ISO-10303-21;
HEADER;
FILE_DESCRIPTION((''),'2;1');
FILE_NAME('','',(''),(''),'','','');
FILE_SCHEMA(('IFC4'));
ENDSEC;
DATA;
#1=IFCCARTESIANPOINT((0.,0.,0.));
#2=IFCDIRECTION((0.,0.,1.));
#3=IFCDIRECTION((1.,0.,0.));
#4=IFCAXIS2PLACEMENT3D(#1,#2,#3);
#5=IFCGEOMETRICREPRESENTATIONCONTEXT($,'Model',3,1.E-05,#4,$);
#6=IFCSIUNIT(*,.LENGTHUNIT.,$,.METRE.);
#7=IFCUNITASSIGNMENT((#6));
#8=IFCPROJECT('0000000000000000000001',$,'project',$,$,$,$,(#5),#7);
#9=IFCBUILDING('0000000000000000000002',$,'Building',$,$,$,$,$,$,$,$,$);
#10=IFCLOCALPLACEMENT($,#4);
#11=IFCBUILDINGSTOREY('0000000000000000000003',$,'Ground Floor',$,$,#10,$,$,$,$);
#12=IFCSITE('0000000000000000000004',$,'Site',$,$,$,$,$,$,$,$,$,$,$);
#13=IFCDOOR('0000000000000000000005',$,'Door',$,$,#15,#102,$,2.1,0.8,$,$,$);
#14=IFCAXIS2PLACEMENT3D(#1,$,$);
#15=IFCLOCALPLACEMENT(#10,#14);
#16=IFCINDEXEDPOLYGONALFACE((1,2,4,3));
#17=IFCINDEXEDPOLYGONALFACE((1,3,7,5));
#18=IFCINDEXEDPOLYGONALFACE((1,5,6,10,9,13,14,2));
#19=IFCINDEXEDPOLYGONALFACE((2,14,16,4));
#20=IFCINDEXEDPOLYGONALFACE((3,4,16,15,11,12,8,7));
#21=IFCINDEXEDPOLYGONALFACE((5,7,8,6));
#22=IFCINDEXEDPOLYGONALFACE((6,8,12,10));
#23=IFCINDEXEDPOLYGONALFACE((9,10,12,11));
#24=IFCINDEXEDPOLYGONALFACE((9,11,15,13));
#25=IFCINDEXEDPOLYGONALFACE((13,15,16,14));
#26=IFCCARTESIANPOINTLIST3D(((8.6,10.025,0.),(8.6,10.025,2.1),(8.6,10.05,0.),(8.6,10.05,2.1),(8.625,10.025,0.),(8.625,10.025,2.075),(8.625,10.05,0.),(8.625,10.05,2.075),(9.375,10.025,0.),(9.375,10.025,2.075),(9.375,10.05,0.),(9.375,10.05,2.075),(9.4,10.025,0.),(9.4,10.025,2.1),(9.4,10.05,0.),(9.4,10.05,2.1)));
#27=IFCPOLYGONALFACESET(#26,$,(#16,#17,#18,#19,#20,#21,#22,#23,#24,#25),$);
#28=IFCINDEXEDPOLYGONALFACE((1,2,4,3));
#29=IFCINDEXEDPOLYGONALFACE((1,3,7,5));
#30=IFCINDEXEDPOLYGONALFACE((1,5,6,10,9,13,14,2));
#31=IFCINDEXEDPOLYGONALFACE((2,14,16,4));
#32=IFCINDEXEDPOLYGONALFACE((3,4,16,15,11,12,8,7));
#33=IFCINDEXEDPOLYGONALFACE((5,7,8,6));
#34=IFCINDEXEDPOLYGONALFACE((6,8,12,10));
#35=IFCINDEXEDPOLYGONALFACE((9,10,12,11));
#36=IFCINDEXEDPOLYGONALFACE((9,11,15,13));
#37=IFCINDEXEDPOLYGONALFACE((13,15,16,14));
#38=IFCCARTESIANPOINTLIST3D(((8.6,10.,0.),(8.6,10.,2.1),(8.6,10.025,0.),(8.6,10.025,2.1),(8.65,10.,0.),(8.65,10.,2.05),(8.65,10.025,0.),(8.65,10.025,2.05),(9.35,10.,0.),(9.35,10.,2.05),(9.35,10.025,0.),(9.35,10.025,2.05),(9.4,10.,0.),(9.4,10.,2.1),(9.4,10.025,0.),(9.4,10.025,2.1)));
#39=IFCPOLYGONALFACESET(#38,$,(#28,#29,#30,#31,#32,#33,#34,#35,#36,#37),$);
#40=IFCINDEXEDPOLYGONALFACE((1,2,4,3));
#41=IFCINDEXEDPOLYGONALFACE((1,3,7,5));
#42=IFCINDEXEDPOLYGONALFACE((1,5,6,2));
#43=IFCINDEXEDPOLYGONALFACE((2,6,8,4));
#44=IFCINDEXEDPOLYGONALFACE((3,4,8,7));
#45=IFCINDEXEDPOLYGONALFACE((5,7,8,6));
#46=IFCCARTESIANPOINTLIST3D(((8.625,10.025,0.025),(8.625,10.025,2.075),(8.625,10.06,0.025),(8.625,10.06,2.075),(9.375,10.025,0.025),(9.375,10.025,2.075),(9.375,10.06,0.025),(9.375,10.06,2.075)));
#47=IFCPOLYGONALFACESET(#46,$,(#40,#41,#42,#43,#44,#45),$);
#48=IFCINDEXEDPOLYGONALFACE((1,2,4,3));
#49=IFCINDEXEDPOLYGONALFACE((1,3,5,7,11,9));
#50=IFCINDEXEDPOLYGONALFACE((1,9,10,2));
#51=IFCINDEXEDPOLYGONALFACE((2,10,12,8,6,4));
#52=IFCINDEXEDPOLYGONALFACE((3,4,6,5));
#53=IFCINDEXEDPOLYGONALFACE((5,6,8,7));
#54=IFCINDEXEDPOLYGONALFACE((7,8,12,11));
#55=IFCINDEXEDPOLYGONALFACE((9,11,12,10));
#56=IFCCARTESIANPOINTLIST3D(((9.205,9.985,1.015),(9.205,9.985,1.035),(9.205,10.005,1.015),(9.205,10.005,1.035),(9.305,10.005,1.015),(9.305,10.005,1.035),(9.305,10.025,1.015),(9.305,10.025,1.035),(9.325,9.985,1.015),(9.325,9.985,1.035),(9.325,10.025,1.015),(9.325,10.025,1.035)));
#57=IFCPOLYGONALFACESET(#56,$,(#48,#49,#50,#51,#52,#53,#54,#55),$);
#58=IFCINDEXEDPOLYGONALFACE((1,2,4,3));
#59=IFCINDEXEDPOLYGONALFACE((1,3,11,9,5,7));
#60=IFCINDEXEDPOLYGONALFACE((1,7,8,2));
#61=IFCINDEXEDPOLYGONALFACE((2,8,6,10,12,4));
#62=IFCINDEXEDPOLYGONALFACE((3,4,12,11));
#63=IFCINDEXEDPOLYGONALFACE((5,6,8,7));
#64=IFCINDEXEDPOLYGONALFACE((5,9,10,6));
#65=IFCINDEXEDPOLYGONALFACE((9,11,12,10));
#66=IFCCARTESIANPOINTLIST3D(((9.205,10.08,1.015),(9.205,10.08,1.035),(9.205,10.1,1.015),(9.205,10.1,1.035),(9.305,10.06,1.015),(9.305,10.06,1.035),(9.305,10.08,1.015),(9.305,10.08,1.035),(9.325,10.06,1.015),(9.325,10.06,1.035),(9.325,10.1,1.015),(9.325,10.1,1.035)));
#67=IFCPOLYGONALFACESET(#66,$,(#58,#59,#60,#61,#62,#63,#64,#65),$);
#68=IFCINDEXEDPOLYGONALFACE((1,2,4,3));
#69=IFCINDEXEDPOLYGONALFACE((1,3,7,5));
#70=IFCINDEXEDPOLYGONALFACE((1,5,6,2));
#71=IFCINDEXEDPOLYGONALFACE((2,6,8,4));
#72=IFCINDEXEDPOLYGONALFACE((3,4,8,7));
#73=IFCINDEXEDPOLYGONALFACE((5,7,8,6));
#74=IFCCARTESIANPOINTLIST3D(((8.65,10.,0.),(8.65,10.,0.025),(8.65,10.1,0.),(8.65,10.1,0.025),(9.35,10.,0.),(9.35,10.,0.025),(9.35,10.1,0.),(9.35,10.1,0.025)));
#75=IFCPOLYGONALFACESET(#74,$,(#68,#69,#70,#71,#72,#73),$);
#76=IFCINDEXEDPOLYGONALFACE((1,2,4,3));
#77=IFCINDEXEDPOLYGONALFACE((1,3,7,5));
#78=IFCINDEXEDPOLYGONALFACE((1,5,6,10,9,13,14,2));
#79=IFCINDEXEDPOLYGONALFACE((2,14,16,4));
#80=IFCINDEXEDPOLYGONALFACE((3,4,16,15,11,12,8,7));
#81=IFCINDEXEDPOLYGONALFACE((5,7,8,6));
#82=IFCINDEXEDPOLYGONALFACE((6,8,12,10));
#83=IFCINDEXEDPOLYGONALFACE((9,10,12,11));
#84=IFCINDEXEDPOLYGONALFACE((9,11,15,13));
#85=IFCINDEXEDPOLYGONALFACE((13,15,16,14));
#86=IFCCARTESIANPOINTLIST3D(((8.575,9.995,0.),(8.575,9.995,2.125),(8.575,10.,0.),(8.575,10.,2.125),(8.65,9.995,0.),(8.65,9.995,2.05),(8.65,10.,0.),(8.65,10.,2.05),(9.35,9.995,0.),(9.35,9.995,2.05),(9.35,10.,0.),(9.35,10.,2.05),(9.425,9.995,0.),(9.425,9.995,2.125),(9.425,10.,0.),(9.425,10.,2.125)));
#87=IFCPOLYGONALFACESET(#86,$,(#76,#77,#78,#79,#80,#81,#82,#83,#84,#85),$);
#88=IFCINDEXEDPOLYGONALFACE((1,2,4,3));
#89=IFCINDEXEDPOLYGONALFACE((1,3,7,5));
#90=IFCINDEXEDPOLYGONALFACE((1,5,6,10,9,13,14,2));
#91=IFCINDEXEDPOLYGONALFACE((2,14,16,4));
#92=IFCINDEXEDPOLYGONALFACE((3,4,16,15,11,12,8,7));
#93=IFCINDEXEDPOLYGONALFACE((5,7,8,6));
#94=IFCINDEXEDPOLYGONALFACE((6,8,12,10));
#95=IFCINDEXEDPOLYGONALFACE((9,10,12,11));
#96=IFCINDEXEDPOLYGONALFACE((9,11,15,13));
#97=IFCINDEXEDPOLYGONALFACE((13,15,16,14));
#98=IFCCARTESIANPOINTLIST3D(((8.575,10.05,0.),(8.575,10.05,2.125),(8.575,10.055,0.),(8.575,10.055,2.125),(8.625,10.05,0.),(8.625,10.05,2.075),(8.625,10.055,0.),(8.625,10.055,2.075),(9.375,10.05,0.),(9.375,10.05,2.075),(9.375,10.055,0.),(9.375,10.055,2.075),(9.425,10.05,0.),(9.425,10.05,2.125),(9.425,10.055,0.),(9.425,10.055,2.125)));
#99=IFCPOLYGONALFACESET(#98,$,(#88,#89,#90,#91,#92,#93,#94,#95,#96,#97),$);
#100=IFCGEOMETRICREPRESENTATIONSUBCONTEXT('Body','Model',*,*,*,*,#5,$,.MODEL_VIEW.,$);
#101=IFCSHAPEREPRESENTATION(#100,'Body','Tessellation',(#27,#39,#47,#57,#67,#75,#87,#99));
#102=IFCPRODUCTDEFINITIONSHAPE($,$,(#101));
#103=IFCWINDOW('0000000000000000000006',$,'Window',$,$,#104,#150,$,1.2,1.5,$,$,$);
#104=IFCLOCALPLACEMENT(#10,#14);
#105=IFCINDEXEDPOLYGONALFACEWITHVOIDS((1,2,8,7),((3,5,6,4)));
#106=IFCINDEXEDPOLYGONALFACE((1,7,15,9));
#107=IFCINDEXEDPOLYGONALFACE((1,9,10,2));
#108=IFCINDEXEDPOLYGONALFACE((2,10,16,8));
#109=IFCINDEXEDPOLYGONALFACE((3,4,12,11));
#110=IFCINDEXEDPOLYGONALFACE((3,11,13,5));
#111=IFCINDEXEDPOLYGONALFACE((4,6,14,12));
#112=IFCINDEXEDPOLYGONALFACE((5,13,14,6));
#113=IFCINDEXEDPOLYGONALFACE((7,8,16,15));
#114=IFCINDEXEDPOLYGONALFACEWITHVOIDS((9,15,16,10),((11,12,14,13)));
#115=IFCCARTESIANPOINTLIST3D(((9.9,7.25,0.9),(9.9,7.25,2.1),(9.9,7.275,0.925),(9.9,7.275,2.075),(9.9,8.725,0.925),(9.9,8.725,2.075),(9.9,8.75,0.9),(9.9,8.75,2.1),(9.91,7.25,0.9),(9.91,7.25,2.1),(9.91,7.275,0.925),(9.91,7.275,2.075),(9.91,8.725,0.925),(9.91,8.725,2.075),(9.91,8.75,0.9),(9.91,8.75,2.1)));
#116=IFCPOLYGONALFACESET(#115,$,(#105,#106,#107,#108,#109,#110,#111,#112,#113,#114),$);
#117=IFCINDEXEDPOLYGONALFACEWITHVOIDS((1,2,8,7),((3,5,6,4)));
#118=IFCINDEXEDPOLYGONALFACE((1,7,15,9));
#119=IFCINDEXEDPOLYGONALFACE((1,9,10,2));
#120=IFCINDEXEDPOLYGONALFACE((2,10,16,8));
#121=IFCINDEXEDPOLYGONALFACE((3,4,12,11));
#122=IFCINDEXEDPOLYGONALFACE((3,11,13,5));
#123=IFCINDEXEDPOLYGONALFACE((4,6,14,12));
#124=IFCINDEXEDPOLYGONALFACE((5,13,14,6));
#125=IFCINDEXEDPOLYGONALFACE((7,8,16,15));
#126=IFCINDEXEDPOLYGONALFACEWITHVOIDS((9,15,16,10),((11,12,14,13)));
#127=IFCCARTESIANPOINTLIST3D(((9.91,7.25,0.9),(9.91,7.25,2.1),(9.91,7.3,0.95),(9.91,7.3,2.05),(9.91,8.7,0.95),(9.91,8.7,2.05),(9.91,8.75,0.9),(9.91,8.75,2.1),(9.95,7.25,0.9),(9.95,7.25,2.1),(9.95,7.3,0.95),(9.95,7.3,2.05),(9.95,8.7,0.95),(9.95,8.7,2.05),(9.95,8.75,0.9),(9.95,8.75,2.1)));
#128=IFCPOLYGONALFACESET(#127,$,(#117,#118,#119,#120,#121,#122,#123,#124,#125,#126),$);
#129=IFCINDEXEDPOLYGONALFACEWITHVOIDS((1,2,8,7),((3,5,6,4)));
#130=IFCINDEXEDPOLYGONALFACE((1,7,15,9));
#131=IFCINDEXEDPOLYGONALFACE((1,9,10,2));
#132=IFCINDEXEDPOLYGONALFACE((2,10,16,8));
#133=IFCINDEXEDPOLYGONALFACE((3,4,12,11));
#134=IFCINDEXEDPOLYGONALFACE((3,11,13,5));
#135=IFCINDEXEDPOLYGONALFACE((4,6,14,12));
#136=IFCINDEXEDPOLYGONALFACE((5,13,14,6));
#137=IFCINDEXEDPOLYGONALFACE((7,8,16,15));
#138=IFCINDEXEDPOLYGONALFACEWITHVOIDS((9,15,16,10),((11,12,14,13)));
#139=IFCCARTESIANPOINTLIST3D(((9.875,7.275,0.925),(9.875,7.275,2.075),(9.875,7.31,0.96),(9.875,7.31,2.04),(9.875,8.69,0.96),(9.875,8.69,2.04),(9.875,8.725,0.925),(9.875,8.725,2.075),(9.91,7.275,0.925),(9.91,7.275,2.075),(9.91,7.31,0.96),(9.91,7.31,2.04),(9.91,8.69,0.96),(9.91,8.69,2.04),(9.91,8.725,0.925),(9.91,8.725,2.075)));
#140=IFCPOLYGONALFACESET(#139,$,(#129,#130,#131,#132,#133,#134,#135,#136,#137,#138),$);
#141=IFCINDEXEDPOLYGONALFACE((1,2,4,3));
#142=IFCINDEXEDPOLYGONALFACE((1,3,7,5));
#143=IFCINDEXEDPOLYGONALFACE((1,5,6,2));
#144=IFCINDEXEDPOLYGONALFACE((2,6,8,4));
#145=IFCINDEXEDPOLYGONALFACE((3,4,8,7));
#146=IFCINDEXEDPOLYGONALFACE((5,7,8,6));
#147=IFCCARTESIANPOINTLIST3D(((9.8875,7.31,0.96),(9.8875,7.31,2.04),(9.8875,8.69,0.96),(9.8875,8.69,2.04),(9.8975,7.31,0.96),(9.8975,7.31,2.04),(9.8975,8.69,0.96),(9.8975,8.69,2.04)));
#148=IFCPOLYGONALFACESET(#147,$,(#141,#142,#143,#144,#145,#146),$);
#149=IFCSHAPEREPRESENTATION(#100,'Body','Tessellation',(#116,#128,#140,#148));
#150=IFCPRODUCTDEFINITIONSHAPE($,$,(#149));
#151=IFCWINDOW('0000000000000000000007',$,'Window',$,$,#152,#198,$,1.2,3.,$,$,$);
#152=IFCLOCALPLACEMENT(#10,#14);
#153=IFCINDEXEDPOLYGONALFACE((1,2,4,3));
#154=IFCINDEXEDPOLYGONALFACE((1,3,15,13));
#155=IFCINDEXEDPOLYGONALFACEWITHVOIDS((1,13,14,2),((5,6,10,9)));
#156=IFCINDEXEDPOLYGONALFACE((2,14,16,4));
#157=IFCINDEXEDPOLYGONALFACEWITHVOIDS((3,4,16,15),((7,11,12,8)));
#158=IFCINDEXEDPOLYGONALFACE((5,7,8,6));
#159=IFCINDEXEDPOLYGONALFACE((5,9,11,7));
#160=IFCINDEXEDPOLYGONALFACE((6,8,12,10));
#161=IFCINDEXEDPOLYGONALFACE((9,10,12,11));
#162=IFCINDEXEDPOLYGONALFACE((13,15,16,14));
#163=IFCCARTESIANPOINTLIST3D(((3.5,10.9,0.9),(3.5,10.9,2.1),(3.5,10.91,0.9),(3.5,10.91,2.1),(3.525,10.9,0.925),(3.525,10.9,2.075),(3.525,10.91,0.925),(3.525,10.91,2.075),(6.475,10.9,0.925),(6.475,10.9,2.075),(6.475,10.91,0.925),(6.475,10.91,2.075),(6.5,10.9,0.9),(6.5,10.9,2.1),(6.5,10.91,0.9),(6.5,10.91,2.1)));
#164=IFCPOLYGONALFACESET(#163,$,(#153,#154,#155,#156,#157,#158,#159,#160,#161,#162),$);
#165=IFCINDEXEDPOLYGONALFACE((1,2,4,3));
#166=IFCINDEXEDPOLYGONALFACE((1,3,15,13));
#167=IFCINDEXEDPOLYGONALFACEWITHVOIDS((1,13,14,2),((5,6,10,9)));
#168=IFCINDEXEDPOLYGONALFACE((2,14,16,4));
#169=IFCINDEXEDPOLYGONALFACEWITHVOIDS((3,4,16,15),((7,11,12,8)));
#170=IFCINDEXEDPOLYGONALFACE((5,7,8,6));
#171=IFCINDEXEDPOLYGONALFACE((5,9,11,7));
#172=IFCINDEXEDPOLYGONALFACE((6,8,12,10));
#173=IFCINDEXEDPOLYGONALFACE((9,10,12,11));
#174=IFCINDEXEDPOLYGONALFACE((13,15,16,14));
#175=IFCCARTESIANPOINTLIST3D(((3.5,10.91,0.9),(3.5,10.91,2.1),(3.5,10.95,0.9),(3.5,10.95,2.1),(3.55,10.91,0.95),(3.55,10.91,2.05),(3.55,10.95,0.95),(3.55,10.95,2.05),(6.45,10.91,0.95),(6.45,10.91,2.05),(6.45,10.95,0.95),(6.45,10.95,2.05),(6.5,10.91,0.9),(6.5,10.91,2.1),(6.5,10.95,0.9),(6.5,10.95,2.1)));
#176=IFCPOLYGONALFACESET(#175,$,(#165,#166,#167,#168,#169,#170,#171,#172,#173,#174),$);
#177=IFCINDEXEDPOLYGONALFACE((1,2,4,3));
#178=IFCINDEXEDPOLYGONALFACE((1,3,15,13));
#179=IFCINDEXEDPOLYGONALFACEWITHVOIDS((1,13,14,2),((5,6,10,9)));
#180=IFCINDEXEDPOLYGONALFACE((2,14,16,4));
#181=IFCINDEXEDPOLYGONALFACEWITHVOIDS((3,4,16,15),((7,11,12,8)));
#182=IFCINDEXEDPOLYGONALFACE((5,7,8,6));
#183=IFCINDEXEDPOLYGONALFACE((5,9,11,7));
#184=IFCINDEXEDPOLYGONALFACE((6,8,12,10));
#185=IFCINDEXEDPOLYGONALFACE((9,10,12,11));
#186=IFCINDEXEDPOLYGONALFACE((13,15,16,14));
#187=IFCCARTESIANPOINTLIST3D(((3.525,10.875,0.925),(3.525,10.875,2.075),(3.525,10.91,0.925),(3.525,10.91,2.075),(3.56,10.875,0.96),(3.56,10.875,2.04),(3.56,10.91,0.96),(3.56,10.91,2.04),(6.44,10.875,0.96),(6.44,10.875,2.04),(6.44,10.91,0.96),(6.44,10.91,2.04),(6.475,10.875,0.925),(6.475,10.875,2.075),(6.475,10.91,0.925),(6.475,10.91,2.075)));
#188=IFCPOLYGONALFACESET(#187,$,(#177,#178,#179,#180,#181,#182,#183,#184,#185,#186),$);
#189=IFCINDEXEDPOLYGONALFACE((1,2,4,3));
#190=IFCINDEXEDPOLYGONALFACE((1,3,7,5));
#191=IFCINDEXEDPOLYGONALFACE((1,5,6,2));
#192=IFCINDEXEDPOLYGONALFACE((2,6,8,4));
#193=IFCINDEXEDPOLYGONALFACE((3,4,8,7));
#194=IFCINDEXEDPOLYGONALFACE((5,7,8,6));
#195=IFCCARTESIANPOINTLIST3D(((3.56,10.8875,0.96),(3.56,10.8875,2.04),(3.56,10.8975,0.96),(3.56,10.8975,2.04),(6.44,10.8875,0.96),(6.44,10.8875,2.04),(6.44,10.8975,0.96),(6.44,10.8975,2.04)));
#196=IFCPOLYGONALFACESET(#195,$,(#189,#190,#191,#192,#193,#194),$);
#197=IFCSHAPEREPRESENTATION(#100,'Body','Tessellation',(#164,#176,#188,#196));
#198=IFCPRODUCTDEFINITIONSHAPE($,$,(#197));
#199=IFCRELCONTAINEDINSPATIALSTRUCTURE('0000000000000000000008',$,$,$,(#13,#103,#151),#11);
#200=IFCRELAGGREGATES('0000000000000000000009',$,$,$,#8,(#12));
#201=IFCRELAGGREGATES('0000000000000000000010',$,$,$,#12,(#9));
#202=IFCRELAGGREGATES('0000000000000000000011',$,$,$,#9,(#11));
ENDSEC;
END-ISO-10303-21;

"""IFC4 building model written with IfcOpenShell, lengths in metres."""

from ifc_helpers import new_model, si_unit, frame, origin_with_axes, place, context, subcontext, project, spatial, line, indexed_curve, outline, extrude, element, save


model = new_model("IFC4")

# Units and contexts
model_context = context("Model", 3, precision=1e-05, world=origin_with_axes())
body_context = subcontext(model_context, "Body", "Model", "MODEL_VIEW")
ifc_project = project(units=[si_unit("LENGTHUNIT", "METRE")], contexts=[model_context])

# Site, building, storey
site = spatial("IfcSite", under=ifc_project, Name="Site")
building = spatial("IfcBuilding", under=site, Name="Building")
storey_placement = place(None, origin_with_axes())
storey = spatial("IfcBuildingStorey", under=building, at=storey_placement, Name="Ground Floor")

# Door
door_1_placement = place(storey_placement, frame((8.6, 10.0, 0.0), z_axis=(0.0, 0.0, 1.0), x_axis=(1.0, 0.0, 0.0)))
element("IfcDoor", 1, at=door_1_placement, inside=storey, Name="Door", OverallHeight=2.1, OverallWidth=0.8, context=body_context, shape_type="SweptSolid", body=[
    extrude(outline(indexed_curve([(0.0, 0.0), (0.0, 2.1), (0.8, 2.1), (0.8, 0.0), (0.775, 0.0), (0.775, 2.075), (0.025, 2.075), (0.025, 0.0)], segments=[line(1, 2, 3, 4, 5, 6, 7, 8, 1)])), frame((0.0, 0.025, 0.0), z_axis=(0.0, -1.0, 0.0), x_axis=(1.0, 0.0, 0.0)), (0.0, 0.0, -1.0), 0.025),
    extrude(outline(indexed_curve([(0.0, 0.0), (0.0, 2.1), (0.8, 2.1), (0.8, 0.0), (0.75, 0.0), (0.75, 2.05), (0.05, 2.05), (0.05, 0.0)], segments=[line(1, 2, 3, 4, 5, 6, 7, 8, 1)])), frame((0.0, 0.0, 0.0), z_axis=(0.0, -1.0, 0.0), x_axis=(1.0, 0.0, 0.0)), (0.0, 0.0, -1.0), 0.025),
    extrude(outline(indexed_curve([(0.0, 0.0), (0.75, 0.0), (0.75, 0.035), (0.0, 0.035)], segments=[line(1, 2, 3, 4, 1)])), frame((0.025, 0.025, 0.025), z_axis=(0.0, 0.0, 1.0), x_axis=(1.0, 0.0, 0.0)), (0.0, 0.0, 1.0), 2.05),
    extrude(outline(indexed_curve([(0.0, 0.0), (0.0, -0.04), (-0.12, -0.04), (-0.12, -0.02), (-0.02, -0.02), (-0.02, 0.0)], segments=[line(1, 2, 3, 4, 5, 6, 1)])), frame((0.725, 0.025, 1.015), z_axis=(0.0, 0.0, 1.0), x_axis=(1.0, 0.0, 0.0)), (0.0, 0.0, 1.0), 0.02),
    extrude(outline(indexed_curve([(0.0, 0.0), (0.0, 0.04), (-0.12, 0.04), (-0.12, 0.02), (-0.02, 0.02), (-0.02, 0.0)], segments=[line(1, 2, 3, 4, 5, 6, 1)])), frame((0.725, 0.06, 1.015), z_axis=(0.0, 0.0, 1.0), x_axis=(1.0, 0.0, 0.0)), (0.0, 0.0, 1.0), 0.02),
    extrude(outline(indexed_curve([(0.0, 0.0), (0.7, 0.0), (0.7, 0.1), (0.0, 0.1)], segments=[line(1, 2, 3, 4, 1)])), frame((0.05, 0.0, 0.0), z_axis=(0.0, 0.0, 1.0), x_axis=(1.0, 0.0, 0.0)), (0.0, 0.0, 1.0), 0.025),
    extrude(outline(indexed_curve([(0.0, 0.0), (0.0, 2.125), (0.85, 2.125), (0.85, 0.0), (0.775, 0.0), (0.775, 2.05), (0.075, 2.05), (0.075, 0.0)], segments=[line(1, 2, 3, 4, 5, 6, 7, 8, 1)])), frame((-0.025, -0.005, 0.0), z_axis=(0.0, -1.0, 0.0), x_axis=(1.0, 0.0, 0.0)), (0.0, 0.0, -1.0), 0.005),
    extrude(outline(indexed_curve([(0.0, 0.0), (0.0, 2.125), (0.85, 2.125), (0.85, 0.0), (0.8, 0.0), (0.8, 2.075), (0.05, 2.075), (0.05, 0.0)], segments=[line(1, 2, 3, 4, 5, 6, 7, 8, 1)])), frame((-0.025, 0.05, 0.0), z_axis=(0.0, -1.0, 0.0), x_axis=(1.0, 0.0, 0.0)), (0.0, 0.0, -1.0), 0.005),
])

# Windows
window_1_placement = place(storey_placement, frame((10.0, 7.25, 0.9), z_axis=(0.0, 0.0, 1.0), x_axis=(0.0, 1.0, 0.0)))
element("IfcWindow", 2, at=window_1_placement, inside=storey, Name="Window", OverallHeight=1.2, OverallWidth=1.5, context=body_context, shape_type="SweptSolid", body=[
    extrude(outline(indexed_curve([(0.0, 0.0), (1.5, 0.0), (1.5, 1.2), (0.0, 1.2)], segments=[line(1, 2, 3, 4, 1)]), holes=[indexed_curve([(0.025, 0.025), (1.475, 0.025), (1.475, 1.175), (0.025, 1.175)], segments=[line(1, 2, 3, 4, 1)])]), frame((0.0, 0.09, 0.0), z_axis=(0.0, -1.0, 0.0), x_axis=(1.0, 0.0, 0.0)), (0.0, 0.0, -1.0), 0.01),
    extrude(outline(indexed_curve([(0.0, 0.0), (1.5, 0.0), (1.5, 1.2), (0.0, 1.2)], segments=[line(1, 2, 3, 4, 1)]), holes=[indexed_curve([(0.05, 0.05), (1.45, 0.05), (1.45, 1.15), (0.05, 1.15)], segments=[line(1, 2, 3, 4, 1)])]), frame((0.0, 0.05, 0.0), z_axis=(0.0, -1.0, 0.0), x_axis=(1.0, 0.0, 0.0)), (0.0, 0.0, -1.0), 0.04),
    extrude(outline(indexed_curve([(0.0, 0.0), (1.45, 0.0), (1.45, 1.15), (0.0, 1.15)], segments=[line(1, 2, 3, 4, 1)]), holes=[indexed_curve([(0.035, 0.035), (1.415, 0.035), (1.415, 1.115), (0.035, 1.115)], segments=[line(1, 2, 3, 4, 1)])]), frame((0.025, 0.09, 0.025), z_axis=(0.0, -1.0, 0.0), x_axis=(1.0, 0.0, 0.0)), (0.0, 0.0, -1.0), 0.035),
    extrude(outline(indexed_curve([(0.035, 0.035), (1.415, 0.035), (1.415, 1.115), (0.035, 1.115)], segments=[line(1, 2, 3, 4, 1)])), frame((0.025, 0.1025, 0.025), z_axis=(0.0, -1.0, 0.0), x_axis=(1.0, 0.0, 0.0)), (0.0, 0.0, -1.0), 0.01),
])
window_2_placement = place(storey_placement, frame((6.5, 11.0, 0.9), z_axis=(0.0, 0.0, 1.0), x_axis=(-1.0, 0.0, 0.0)))
element("IfcWindow", 3, at=window_2_placement, inside=storey, Name="Window", OverallHeight=1.2, OverallWidth=3.0, context=body_context, shape_type="SweptSolid", body=[
    extrude(outline(indexed_curve([(0.0, 0.0), (3.0, 0.0), (3.0, 1.2), (0.0, 1.2)], segments=[line(1, 2, 3, 4, 1)]), holes=[indexed_curve([(0.025, 0.025), (2.975, 0.025), (2.975, 1.175), (0.025, 1.175)], segments=[line(1, 2, 3, 4, 1)])]), frame((0.0, 0.09, 0.0), z_axis=(0.0, -1.0, 0.0), x_axis=(1.0, 0.0, 0.0)), (0.0, 0.0, -1.0), 0.01),
    extrude(outline(indexed_curve([(0.0, 0.0), (3.0, 0.0), (3.0, 1.2), (0.0, 1.2)], segments=[line(1, 2, 3, 4, 1)]), holes=[indexed_curve([(0.05, 0.05), (2.95, 0.05), (2.95, 1.15), (0.05, 1.15)], segments=[line(1, 2, 3, 4, 1)])]), frame((0.0, 0.05, 0.0), z_axis=(0.0, -1.0, 0.0), x_axis=(1.0, 0.0, 0.0)), (0.0, 0.0, -1.0), 0.04),
    extrude(outline(indexed_curve([(0.0, 0.0), (2.95, 0.0), (2.95, 1.15), (0.0, 1.15)], segments=[line(1, 2, 3, 4, 1)]), holes=[indexed_curve([(0.035, 0.035), (2.915, 0.035), (2.915, 1.115), (0.035, 1.115)], segments=[line(1, 2, 3, 4, 1)])]), frame((0.025, 0.09, 0.025), z_axis=(0.0, -1.0, 0.0), x_axis=(1.0, 0.0, 0.0)), (0.0, 0.0, -1.0), 0.035),
    extrude(outline(indexed_curve([(0.035, 0.035), (2.915, 0.035), (2.915, 1.115), (0.035, 1.115)], segments=[line(1, 2, 3, 4, 1)])), frame((0.025, 0.1025, 0.025), z_axis=(0.0, -1.0, 0.0), x_axis=(1.0, 0.0, 0.0)), (0.0, 0.0, -1.0), 0.01),
])

save(model, "model.ifc")
